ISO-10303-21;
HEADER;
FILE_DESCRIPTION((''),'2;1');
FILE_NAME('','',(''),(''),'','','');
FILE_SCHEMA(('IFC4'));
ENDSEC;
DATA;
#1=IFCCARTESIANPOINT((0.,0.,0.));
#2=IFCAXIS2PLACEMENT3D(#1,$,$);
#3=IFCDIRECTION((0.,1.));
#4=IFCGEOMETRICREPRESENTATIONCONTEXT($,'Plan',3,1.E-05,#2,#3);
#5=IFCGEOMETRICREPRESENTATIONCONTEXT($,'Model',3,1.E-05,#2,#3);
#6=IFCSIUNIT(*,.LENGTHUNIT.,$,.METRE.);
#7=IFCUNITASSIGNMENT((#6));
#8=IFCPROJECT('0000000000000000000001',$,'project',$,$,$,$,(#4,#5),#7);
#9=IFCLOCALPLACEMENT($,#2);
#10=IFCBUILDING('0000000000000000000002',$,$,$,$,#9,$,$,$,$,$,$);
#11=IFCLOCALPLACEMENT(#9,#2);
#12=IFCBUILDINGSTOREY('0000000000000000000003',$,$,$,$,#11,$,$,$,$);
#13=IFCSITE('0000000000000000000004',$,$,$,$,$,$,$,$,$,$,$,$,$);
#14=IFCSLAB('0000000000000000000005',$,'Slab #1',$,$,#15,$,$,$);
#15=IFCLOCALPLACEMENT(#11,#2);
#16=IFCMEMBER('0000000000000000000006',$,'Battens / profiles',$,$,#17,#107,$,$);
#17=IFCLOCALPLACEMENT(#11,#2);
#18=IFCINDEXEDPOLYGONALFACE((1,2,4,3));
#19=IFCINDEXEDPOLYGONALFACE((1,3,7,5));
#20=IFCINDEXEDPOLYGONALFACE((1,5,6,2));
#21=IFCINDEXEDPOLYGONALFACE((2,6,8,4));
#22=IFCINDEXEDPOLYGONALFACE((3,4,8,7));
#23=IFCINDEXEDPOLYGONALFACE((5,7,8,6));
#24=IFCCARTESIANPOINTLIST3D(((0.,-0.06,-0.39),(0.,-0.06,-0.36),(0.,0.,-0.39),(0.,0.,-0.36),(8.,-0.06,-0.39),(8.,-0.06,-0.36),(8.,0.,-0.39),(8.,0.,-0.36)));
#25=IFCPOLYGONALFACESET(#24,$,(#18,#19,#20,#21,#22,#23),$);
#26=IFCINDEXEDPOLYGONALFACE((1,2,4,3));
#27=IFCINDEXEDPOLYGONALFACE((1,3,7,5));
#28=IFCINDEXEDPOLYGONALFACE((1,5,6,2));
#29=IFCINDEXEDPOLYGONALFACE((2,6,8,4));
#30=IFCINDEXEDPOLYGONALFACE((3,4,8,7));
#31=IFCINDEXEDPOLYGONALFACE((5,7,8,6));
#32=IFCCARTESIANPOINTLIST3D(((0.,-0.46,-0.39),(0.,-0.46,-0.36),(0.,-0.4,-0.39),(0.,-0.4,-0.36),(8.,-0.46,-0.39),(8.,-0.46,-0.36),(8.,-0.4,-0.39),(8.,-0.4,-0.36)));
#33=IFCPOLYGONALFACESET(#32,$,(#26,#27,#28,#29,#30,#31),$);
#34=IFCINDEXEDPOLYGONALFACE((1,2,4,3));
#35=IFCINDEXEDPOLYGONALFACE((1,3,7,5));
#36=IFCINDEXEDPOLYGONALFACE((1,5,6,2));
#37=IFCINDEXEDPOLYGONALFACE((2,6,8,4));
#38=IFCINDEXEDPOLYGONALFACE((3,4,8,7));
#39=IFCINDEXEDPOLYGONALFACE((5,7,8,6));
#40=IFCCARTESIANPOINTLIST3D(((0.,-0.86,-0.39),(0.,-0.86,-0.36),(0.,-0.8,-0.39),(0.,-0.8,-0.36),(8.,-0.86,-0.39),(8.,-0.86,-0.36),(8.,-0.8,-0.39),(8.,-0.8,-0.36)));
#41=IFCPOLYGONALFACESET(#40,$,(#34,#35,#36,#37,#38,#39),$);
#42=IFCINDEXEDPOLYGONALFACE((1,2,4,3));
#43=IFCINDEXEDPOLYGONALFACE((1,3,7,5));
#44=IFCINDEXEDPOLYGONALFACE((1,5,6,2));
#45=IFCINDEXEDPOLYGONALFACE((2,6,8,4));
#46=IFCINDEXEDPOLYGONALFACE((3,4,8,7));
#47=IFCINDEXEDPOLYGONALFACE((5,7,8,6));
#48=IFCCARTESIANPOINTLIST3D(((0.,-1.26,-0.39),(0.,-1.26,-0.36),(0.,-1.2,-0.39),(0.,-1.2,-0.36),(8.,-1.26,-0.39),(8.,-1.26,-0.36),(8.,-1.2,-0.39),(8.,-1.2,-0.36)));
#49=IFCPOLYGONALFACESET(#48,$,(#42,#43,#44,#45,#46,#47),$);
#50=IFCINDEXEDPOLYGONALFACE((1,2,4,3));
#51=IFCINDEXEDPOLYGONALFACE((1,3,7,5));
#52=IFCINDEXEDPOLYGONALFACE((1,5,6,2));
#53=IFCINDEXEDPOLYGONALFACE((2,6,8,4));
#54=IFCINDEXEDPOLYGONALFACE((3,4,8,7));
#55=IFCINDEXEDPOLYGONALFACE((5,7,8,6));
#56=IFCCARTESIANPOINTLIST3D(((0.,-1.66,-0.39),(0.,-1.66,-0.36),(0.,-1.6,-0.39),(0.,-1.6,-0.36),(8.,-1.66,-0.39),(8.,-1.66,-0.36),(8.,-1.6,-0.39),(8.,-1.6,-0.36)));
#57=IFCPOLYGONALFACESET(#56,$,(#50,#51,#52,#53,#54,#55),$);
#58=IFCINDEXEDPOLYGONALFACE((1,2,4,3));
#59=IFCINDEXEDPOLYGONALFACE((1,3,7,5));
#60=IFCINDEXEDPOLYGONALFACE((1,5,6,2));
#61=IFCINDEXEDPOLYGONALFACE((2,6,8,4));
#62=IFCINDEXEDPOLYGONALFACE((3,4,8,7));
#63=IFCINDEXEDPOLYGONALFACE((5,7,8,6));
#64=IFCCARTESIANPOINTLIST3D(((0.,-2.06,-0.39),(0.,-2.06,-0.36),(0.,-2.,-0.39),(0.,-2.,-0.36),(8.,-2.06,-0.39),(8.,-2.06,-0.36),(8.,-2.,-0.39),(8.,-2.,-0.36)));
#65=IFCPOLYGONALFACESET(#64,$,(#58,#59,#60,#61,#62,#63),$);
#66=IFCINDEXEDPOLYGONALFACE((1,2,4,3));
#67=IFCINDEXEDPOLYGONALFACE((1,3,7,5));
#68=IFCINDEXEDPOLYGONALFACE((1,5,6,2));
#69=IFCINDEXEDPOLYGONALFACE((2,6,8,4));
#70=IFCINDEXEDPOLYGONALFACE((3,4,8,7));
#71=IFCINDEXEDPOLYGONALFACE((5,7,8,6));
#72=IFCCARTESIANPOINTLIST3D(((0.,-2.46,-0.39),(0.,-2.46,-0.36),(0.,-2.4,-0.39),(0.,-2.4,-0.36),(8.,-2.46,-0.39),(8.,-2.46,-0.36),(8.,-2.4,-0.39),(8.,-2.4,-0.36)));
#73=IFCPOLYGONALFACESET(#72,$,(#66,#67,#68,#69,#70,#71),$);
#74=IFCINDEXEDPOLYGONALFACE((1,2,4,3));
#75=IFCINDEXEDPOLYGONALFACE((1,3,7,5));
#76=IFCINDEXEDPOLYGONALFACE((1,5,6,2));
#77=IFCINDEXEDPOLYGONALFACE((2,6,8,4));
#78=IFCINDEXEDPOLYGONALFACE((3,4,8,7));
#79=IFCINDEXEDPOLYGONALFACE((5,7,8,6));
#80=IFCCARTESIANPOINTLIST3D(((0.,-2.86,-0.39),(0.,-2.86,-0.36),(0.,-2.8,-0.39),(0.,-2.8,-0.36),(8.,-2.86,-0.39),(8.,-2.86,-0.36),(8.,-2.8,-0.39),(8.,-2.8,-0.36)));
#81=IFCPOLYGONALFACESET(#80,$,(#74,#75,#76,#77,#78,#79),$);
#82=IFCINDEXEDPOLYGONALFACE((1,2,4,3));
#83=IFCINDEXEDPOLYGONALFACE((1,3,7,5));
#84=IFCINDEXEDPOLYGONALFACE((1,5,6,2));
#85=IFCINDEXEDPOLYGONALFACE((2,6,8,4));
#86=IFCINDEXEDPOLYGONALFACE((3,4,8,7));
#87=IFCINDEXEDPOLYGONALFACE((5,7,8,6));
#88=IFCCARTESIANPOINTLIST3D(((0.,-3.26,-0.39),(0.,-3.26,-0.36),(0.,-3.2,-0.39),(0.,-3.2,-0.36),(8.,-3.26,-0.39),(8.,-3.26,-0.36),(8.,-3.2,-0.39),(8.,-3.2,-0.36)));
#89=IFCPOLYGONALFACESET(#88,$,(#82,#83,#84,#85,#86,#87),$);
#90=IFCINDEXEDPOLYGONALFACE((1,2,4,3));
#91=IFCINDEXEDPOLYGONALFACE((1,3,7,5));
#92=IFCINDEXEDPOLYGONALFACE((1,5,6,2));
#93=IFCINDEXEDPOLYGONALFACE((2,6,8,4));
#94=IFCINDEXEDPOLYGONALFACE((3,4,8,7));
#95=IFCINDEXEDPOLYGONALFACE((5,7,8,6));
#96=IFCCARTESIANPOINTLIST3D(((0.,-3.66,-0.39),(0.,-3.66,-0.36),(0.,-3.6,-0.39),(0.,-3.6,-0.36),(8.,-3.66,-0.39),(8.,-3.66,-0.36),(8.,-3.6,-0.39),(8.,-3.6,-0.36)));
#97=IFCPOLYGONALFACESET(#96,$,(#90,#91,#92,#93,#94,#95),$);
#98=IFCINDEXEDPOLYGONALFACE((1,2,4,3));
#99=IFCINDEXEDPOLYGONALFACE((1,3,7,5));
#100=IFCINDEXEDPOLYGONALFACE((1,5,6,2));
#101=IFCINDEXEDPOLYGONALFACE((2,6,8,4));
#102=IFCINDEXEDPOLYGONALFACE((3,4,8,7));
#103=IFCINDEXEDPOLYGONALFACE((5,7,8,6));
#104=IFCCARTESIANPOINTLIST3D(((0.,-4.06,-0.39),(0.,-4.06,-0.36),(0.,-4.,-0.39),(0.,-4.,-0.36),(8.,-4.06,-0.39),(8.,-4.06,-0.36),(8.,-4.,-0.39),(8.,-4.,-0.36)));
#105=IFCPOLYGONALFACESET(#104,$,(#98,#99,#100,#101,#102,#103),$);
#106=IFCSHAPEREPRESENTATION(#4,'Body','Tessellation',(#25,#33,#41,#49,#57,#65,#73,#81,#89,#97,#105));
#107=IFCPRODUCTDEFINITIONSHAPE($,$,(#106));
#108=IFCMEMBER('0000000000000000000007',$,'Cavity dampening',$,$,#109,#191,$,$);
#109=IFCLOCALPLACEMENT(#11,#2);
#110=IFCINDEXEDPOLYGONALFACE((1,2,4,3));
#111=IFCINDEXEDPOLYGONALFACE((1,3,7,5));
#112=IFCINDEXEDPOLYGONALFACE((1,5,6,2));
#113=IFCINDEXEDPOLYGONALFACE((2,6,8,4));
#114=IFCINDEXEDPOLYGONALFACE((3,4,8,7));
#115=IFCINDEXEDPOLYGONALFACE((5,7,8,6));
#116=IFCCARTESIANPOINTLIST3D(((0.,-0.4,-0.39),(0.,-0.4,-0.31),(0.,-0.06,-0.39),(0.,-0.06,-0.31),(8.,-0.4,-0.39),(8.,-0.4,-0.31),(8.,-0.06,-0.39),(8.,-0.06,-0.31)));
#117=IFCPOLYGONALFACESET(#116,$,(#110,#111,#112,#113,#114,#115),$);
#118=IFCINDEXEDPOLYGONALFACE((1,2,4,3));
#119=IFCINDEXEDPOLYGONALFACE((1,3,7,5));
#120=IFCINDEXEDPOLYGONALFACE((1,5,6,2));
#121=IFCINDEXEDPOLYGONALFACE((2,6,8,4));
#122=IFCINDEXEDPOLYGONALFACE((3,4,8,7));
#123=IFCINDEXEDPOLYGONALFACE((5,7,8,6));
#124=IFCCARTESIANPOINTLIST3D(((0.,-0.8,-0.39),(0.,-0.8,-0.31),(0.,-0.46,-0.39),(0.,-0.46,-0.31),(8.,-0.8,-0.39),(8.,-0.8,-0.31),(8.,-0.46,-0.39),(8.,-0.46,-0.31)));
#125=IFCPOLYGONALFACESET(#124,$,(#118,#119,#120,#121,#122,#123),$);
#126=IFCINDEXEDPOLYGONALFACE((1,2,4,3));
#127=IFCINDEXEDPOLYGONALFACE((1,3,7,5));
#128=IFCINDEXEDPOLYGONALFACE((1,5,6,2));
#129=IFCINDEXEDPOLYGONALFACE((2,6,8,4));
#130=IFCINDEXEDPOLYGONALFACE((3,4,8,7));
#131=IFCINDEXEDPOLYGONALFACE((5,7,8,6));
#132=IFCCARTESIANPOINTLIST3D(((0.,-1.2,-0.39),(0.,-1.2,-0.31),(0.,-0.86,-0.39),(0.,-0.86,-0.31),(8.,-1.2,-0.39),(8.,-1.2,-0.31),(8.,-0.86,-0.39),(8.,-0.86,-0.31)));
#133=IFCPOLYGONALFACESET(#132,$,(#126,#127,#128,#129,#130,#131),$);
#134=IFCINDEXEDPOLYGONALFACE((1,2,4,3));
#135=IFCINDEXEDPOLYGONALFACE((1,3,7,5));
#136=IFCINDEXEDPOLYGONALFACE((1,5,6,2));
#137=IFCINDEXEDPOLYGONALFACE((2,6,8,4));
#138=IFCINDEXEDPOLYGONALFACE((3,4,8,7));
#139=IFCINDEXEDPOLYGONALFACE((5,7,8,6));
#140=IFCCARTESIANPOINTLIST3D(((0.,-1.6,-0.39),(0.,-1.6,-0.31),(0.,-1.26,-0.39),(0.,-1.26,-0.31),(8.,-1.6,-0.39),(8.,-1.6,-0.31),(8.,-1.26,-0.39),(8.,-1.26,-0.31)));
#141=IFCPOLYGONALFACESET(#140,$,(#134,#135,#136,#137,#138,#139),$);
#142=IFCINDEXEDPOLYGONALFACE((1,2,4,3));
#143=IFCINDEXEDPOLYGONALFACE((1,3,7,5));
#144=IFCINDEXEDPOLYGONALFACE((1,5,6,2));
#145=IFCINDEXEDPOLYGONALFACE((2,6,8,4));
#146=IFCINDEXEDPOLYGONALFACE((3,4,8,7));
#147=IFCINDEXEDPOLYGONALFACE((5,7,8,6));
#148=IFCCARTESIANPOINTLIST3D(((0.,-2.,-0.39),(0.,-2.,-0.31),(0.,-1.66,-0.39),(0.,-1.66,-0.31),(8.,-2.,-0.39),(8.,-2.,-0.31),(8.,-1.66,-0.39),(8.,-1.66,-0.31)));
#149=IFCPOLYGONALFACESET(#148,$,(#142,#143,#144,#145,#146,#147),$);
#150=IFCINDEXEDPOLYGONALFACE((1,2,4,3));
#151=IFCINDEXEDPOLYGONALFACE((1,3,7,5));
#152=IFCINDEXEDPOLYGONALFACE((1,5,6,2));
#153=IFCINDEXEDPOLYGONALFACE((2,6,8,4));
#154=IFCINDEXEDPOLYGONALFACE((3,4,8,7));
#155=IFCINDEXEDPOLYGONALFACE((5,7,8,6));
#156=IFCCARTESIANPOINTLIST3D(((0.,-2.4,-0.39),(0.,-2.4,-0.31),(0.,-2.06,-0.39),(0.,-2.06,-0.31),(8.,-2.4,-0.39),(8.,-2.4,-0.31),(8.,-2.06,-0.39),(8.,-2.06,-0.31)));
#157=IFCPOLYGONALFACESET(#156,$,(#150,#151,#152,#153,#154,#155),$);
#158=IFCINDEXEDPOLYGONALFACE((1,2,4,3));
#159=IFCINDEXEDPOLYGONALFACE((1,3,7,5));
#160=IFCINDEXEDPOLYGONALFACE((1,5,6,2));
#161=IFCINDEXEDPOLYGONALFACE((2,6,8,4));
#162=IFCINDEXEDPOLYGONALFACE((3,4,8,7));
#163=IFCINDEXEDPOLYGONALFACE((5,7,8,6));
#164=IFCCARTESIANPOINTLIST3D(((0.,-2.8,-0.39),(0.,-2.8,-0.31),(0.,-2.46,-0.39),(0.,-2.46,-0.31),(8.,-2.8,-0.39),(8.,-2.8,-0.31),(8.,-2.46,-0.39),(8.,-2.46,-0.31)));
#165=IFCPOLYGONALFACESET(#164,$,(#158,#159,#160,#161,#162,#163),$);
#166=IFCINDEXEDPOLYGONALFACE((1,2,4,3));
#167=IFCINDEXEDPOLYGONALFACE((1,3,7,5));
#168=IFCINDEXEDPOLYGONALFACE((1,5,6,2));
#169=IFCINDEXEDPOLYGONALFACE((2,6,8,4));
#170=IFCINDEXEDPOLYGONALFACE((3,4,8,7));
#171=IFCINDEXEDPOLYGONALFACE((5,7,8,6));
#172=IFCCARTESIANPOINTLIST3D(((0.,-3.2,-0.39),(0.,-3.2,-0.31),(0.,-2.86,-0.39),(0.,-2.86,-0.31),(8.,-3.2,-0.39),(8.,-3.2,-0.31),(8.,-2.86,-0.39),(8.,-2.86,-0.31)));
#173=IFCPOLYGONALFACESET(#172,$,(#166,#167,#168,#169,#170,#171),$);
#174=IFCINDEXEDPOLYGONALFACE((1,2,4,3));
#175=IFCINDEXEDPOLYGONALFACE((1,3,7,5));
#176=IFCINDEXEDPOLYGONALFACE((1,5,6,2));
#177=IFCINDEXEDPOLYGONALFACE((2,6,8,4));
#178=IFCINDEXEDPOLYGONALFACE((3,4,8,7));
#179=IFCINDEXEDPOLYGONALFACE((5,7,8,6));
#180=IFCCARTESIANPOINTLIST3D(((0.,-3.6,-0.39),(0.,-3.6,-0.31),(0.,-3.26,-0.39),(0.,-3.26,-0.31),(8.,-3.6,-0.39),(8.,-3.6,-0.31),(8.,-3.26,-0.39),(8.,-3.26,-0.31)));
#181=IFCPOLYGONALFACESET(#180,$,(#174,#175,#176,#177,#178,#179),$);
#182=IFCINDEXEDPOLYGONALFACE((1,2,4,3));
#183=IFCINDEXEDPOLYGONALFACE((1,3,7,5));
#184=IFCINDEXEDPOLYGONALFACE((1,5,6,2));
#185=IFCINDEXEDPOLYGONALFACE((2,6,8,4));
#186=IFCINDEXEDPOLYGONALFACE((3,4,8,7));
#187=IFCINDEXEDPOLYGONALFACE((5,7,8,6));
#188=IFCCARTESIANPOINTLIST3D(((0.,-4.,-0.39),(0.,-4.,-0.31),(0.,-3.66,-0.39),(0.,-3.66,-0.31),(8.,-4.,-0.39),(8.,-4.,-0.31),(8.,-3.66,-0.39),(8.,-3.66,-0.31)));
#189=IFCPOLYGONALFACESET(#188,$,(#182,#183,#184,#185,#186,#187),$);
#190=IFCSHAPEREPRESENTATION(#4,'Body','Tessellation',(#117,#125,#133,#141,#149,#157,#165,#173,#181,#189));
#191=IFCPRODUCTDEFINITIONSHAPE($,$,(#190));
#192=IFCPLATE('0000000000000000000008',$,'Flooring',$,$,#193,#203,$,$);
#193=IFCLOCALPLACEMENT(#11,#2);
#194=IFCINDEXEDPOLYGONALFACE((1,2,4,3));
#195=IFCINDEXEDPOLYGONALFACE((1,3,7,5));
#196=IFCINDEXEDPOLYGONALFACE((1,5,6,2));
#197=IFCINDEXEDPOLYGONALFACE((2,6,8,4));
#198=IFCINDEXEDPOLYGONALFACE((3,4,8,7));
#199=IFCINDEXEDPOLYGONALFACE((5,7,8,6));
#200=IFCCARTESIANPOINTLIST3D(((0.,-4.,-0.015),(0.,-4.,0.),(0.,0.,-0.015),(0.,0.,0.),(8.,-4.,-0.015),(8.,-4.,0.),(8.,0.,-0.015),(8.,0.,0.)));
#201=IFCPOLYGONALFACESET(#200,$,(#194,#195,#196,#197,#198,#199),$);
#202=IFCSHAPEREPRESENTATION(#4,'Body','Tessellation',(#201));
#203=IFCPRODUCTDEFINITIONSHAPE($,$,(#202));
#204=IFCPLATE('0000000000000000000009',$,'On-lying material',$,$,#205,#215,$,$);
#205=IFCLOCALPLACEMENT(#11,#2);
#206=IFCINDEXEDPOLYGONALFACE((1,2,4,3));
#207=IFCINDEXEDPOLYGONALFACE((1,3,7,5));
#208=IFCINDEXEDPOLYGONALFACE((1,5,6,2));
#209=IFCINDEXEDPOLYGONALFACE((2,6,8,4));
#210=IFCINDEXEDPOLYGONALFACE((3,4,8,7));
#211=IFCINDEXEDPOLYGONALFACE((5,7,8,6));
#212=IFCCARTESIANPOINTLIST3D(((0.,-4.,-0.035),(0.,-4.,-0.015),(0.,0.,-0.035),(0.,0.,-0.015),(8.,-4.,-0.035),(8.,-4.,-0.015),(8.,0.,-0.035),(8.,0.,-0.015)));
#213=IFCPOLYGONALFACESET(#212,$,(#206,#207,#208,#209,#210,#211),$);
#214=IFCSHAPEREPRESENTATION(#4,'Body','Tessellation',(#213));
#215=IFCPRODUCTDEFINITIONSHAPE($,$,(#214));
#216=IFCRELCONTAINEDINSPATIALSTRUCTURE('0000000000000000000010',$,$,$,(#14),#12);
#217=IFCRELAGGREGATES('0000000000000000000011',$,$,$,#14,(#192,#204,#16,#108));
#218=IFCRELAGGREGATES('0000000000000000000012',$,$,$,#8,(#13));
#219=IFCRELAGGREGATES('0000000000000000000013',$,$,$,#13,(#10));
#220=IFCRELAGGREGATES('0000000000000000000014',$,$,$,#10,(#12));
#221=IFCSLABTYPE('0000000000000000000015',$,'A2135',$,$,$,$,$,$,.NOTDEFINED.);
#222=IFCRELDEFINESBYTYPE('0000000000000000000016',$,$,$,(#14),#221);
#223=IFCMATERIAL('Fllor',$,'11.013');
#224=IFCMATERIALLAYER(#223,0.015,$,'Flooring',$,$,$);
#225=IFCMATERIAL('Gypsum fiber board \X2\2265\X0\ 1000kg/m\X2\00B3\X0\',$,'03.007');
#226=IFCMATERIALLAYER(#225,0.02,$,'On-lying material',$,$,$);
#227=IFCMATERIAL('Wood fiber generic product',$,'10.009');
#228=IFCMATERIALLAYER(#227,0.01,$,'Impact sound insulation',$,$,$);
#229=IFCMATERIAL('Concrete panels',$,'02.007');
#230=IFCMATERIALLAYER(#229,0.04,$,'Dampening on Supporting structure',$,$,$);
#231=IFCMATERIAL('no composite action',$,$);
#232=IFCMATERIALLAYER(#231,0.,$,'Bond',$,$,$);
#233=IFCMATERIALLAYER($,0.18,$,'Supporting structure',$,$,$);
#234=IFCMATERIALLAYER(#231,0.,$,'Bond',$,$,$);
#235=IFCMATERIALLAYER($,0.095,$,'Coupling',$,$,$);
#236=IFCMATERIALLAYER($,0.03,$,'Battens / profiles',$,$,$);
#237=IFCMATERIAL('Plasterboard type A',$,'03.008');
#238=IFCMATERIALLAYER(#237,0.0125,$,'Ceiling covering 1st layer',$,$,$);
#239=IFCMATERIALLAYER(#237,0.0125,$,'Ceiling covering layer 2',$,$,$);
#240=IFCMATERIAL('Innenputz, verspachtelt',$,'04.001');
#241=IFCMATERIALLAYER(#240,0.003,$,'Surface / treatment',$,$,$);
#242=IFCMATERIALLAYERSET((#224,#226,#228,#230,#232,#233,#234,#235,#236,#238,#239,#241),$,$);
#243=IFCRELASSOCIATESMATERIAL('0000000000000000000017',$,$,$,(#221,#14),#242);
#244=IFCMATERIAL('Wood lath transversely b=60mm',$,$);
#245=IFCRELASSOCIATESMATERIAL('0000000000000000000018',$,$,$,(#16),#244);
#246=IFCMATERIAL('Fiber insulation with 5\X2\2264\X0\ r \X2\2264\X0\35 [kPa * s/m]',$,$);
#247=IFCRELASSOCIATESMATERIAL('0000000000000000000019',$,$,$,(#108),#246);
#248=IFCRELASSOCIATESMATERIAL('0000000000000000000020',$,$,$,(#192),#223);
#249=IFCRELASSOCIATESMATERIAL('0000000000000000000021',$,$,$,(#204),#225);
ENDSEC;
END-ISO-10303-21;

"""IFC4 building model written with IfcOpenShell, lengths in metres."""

from ifc_helpers import new_model, si_unit, direction, frame, frame_2d, origin, origin_with_axes, place, context, project, spatial, rectangle, extrude, material, layer, layer_set, type_object, element, aggregate, save


model = new_model("IFC4")

# Units and contexts
plan_context = context("Plan", 3, precision=1e-05, world=origin(), true_north=direction((0.0, 1.0)))
model_context = context("Model", 3, precision=1e-05, world=origin(), true_north=direction((0.0, 1.0)))
ifc_project = project(units=[si_unit("LENGTHUNIT", "METRE")], contexts=[plan_context, model_context])

# Site, building, storey
site = spatial("IfcSite", under=ifc_project)
building_placement = place(None, origin())
building = spatial("IfcBuilding", under=site, at=building_placement)
storey_placement = place(building_placement, origin())
storey = spatial("IfcBuildingStorey", under=building, at=storey_placement)

# Slab, members, plates
ifc_material_1 = material(Name="Fllor", Category="11.013")
ifc_layer_1 = layer(ifc_material_1, 0.015, Name="Flooring")
ifc_material_2 = material(Name="Gypsum fiber board ≥ 1000kg/m³", Category="03.007")
ifc_layer_2 = layer(ifc_material_2, 0.02, Name="On-lying material")
ifc_material_3 = material(Name="Wood fiber generic product", Category="10.009")
ifc_layer_3 = layer(ifc_material_3, 0.01, Name="Impact sound insulation")
ifc_material_4 = material(Name="Concrete panels", Category="02.007")
ifc_layer_4 = layer(ifc_material_4, 0.04, Name="Dampening on Supporting structure")
ifc_material_5 = material(Name="no composite action")
ifc_layer_5 = layer(ifc_material_5, 0.0, Name="Bond")
ifc_layer_6 = layer(None, 0.18, Name="Supporting structure")
ifc_layer_7 = layer(ifc_material_5, 0.0, Name="Bond")
ifc_layer_8 = layer(None, 0.095, Name="Coupling")
ifc_layer_9 = layer(None, 0.03, Name="Battens / profiles")
ifc_material_6 = material(Name="Plasterboard type A", Category="03.008")
ifc_layer_10 = layer(ifc_material_6, 0.0125, Name="Ceiling covering 1st layer")
ifc_layer_11 = layer(ifc_material_6, 0.0125, Name="Ceiling covering layer 2")
ifc_material_7 = material(Name="Innenputz, verspachtelt", Category="04.001")
ifc_layer_12 = layer(ifc_material_7, 0.003, Name="Surface / treatment")
ifc_layer_set = layer_set([ifc_layer_1, ifc_layer_2, ifc_layer_3, ifc_layer_4, ifc_layer_5, ifc_layer_6, ifc_layer_7, ifc_layer_8, ifc_layer_9, ifc_layer_10, ifc_layer_11, ifc_layer_12])
slab_type = type_object("IfcSlabType", Name="A2135", PredefinedType="NOTDEFINED", material=ifc_layer_set)
slab_placement = place(None, frame((0.0, 0.0, 0.0), z_axis=(0.0, 0.0, -1.0), x_axis=(1.0, 0.0, 0.0)))
slab = element("IfcSlab", 1, at=slab_placement, inside=storey, type_object=slab_type, material=ifc_layer_set, Name="Slab #1")
ifc_material_8 = material(Name="Wood lath transversely b=60mm")
member_1_placement = place(slab_placement, origin())
member_1 = element("IfcMember", 2, at=member_1_placement, material=ifc_material_8, Name="Battens / profiles", context=plan_context, shape_type="SweptSolid", body=[
    extrude(rectangle(XDim=0.06, YDim=0.03, at=frame_2d((0.03, 0.015), x_axis=(1.0, 0.0))), frame((0.0, 0.0, 0.36), z_axis=(1.0, 0.0, 0.0), x_axis=(0.0, 1.0, 0.0)), (0.0, 0.0, 1.0), 8.0),
    extrude(rectangle(XDim=0.06, YDim=0.03, at=frame_2d((0.03, 0.015), x_axis=(1.0, 0.0))), frame((0.0, 0.4, 0.36), z_axis=(1.0, 0.0, 0.0), x_axis=(0.0, 1.0, 0.0)), (0.0, 0.0, 1.0), 8.0),
    extrude(rectangle(XDim=0.06, YDim=0.03, at=frame_2d((0.03, 0.015), x_axis=(1.0, 0.0))), frame((0.0, 0.8, 0.36), z_axis=(1.0, 0.0, 0.0), x_axis=(0.0, 1.0, 0.0)), (0.0, 0.0, 1.0), 8.0),
    extrude(rectangle(XDim=0.06, YDim=0.03, at=frame_2d((0.03, 0.015), x_axis=(1.0, 0.0))), frame((0.0, 1.2, 0.36), z_axis=(1.0, 0.0, 0.0), x_axis=(0.0, 1.0, 0.0)), (0.0, 0.0, 1.0), 8.0),
    extrude(rectangle(XDim=0.06, YDim=0.03, at=frame_2d((0.03, 0.015), x_axis=(1.0, 0.0))), frame((0.0, 1.6, 0.36), z_axis=(1.0, 0.0, 0.0), x_axis=(0.0, 1.0, 0.0)), (0.0, 0.0, 1.0), 8.0),
    extrude(rectangle(XDim=0.06, YDim=0.03, at=frame_2d((0.03, 0.015), x_axis=(1.0, 0.0))), frame((0.0, 2.0, 0.36), z_axis=(1.0, 0.0, 0.0), x_axis=(0.0, 1.0, 0.0)), (0.0, 0.0, 1.0), 8.0),
    extrude(rectangle(XDim=0.06, YDim=0.03, at=frame_2d((0.03, 0.015), x_axis=(1.0, 0.0))), frame((0.0, 2.4, 0.36), z_axis=(1.0, 0.0, 0.0), x_axis=(0.0, 1.0, 0.0)), (0.0, 0.0, 1.0), 8.0),
    extrude(rectangle(XDim=0.06, YDim=0.03, at=frame_2d((0.03, 0.015), x_axis=(1.0, 0.0))), frame((0.0, 2.8, 0.36), z_axis=(1.0, 0.0, 0.0), x_axis=(0.0, 1.0, 0.0)), (0.0, 0.0, 1.0), 8.0),
    extrude(rectangle(XDim=0.06, YDim=0.03, at=frame_2d((0.03, 0.015), x_axis=(1.0, 0.0))), frame((0.0, 3.2, 0.36), z_axis=(1.0, 0.0, 0.0), x_axis=(0.0, 1.0, 0.0)), (0.0, 0.0, 1.0), 8.0),
    extrude(rectangle(XDim=0.06, YDim=0.03, at=frame_2d((0.03, 0.015), x_axis=(1.0, 0.0))), frame((0.0, 3.6, 0.36), z_axis=(1.0, 0.0, 0.0), x_axis=(0.0, 1.0, 0.0)), (0.0, 0.0, 1.0), 8.0),
    extrude(rectangle(XDim=0.06, YDim=0.03, at=frame_2d((0.03, 0.015), x_axis=(1.0, 0.0))), frame((0.0, 4.0, 0.36), z_axis=(1.0, 0.0, 0.0), x_axis=(0.0, 1.0, 0.0)), (0.0, 0.0, 1.0), 8.0),
])
ifc_material_9 = material(Name="Fiber insulation with 5≤ r ≤35 [kPa * s/m]")
member_2_placement = place(slab_placement, origin())
member_2 = element("IfcMember", 3, at=member_2_placement, material=ifc_material_9, Name="Cavity dampening", context=plan_context, shape_type="SweptSolid", body=[
    extrude(rectangle(XDim=0.34, YDim=0.08, at=frame_2d((0.17, 0.04), x_axis=(1.0, 0.0))), frame((0.0, 0.06, 0.31), z_axis=(1.0, 0.0, 0.0), x_axis=(0.0, 1.0, 0.0)), (0.0, 0.0, 1.0), 8.0),
    extrude(rectangle(XDim=0.34, YDim=0.08, at=frame_2d((0.17, 0.04), x_axis=(1.0, 0.0))), frame((0.0, 0.46, 0.31), z_axis=(1.0, 0.0, 0.0), x_axis=(0.0, 1.0, 0.0)), (0.0, 0.0, 1.0), 8.0),
    extrude(rectangle(XDim=0.34, YDim=0.08, at=frame_2d((0.17, 0.04), x_axis=(1.0, 0.0))), frame((0.0, 0.86, 0.31), z_axis=(1.0, 0.0, 0.0), x_axis=(0.0, 1.0, 0.0)), (0.0, 0.0, 1.0), 8.0),
    extrude(rectangle(XDim=0.34, YDim=0.08, at=frame_2d((0.17, 0.04), x_axis=(1.0, 0.0))), frame((0.0, 1.26, 0.31), z_axis=(1.0, 0.0, 0.0), x_axis=(0.0, 1.0, 0.0)), (0.0, 0.0, 1.0), 8.0),
    extrude(rectangle(XDim=0.34, YDim=0.08, at=frame_2d((0.17, 0.04), x_axis=(1.0, 0.0))), frame((0.0, 1.66, 0.31), z_axis=(1.0, 0.0, 0.0), x_axis=(0.0, 1.0, 0.0)), (0.0, 0.0, 1.0), 8.0),
    extrude(rectangle(XDim=0.34, YDim=0.08, at=frame_2d((0.17, 0.04), x_axis=(1.0, 0.0))), frame((0.0, 2.06, 0.31), z_axis=(1.0, 0.0, 0.0), x_axis=(0.0, 1.0, 0.0)), (0.0, 0.0, 1.0), 8.0),
    extrude(rectangle(XDim=0.34, YDim=0.08, at=frame_2d((0.17, 0.04), x_axis=(1.0, 0.0))), frame((0.0, 2.46, 0.31), z_axis=(1.0, 0.0, 0.0), x_axis=(0.0, 1.0, 0.0)), (0.0, 0.0, 1.0), 8.0),
    extrude(rectangle(XDim=0.34, YDim=0.08, at=frame_2d((0.17, 0.04), x_axis=(1.0, 0.0))), frame((0.0, 2.86, 0.31), z_axis=(1.0, 0.0, 0.0), x_axis=(0.0, 1.0, 0.0)), (0.0, 0.0, 1.0), 8.0),
    extrude(rectangle(XDim=0.34, YDim=0.08, at=frame_2d((0.17, 0.04), x_axis=(1.0, 0.0))), frame((0.0, 3.26, 0.31), z_axis=(1.0, 0.0, 0.0), x_axis=(0.0, 1.0, 0.0)), (0.0, 0.0, 1.0), 8.0),
    extrude(rectangle(XDim=0.34, YDim=0.08, at=frame_2d((0.17, 0.04), x_axis=(1.0, 0.0))), frame((0.0, 3.66, 0.31), z_axis=(1.0, 0.0, 0.0), x_axis=(0.0, 1.0, 0.0)), (0.0, 0.0, 1.0), 8.0),
])
plate_1_placement = place(slab_placement, origin())
plate_1 = element("IfcPlate", 4, at=plate_1_placement, material=ifc_material_1, Name="Flooring", context=plan_context, shape_type="SweptSolid", body=[
    extrude(rectangle(XDim=8.0, YDim=4.0, at=frame_2d((4.0, 2.0), x_axis=(1.0, 0.0))), origin_with_axes(), (0.0, 0.0, 1.0), 0.015),
])
plate_2_placement = place(slab_placement, origin())
plate_2 = element("IfcPlate", 5, at=plate_2_placement, material=ifc_material_2, Name="On-lying material", context=plan_context, shape_type="SweptSolid", body=[
    extrude(rectangle(XDim=8.0, YDim=4.0, at=frame_2d((4.0, 2.0), x_axis=(1.0, 0.0))), frame((0.0, 0.0, 0.015), z_axis=(0.0, 0.0, 1.0), x_axis=(1.0, 0.0, 0.0)), (0.0, 0.0, 1.0), 0.02),
])
aggregate(slab, [plate_1, plate_2, member_1, member_2])

save(model, "model.ifc")
